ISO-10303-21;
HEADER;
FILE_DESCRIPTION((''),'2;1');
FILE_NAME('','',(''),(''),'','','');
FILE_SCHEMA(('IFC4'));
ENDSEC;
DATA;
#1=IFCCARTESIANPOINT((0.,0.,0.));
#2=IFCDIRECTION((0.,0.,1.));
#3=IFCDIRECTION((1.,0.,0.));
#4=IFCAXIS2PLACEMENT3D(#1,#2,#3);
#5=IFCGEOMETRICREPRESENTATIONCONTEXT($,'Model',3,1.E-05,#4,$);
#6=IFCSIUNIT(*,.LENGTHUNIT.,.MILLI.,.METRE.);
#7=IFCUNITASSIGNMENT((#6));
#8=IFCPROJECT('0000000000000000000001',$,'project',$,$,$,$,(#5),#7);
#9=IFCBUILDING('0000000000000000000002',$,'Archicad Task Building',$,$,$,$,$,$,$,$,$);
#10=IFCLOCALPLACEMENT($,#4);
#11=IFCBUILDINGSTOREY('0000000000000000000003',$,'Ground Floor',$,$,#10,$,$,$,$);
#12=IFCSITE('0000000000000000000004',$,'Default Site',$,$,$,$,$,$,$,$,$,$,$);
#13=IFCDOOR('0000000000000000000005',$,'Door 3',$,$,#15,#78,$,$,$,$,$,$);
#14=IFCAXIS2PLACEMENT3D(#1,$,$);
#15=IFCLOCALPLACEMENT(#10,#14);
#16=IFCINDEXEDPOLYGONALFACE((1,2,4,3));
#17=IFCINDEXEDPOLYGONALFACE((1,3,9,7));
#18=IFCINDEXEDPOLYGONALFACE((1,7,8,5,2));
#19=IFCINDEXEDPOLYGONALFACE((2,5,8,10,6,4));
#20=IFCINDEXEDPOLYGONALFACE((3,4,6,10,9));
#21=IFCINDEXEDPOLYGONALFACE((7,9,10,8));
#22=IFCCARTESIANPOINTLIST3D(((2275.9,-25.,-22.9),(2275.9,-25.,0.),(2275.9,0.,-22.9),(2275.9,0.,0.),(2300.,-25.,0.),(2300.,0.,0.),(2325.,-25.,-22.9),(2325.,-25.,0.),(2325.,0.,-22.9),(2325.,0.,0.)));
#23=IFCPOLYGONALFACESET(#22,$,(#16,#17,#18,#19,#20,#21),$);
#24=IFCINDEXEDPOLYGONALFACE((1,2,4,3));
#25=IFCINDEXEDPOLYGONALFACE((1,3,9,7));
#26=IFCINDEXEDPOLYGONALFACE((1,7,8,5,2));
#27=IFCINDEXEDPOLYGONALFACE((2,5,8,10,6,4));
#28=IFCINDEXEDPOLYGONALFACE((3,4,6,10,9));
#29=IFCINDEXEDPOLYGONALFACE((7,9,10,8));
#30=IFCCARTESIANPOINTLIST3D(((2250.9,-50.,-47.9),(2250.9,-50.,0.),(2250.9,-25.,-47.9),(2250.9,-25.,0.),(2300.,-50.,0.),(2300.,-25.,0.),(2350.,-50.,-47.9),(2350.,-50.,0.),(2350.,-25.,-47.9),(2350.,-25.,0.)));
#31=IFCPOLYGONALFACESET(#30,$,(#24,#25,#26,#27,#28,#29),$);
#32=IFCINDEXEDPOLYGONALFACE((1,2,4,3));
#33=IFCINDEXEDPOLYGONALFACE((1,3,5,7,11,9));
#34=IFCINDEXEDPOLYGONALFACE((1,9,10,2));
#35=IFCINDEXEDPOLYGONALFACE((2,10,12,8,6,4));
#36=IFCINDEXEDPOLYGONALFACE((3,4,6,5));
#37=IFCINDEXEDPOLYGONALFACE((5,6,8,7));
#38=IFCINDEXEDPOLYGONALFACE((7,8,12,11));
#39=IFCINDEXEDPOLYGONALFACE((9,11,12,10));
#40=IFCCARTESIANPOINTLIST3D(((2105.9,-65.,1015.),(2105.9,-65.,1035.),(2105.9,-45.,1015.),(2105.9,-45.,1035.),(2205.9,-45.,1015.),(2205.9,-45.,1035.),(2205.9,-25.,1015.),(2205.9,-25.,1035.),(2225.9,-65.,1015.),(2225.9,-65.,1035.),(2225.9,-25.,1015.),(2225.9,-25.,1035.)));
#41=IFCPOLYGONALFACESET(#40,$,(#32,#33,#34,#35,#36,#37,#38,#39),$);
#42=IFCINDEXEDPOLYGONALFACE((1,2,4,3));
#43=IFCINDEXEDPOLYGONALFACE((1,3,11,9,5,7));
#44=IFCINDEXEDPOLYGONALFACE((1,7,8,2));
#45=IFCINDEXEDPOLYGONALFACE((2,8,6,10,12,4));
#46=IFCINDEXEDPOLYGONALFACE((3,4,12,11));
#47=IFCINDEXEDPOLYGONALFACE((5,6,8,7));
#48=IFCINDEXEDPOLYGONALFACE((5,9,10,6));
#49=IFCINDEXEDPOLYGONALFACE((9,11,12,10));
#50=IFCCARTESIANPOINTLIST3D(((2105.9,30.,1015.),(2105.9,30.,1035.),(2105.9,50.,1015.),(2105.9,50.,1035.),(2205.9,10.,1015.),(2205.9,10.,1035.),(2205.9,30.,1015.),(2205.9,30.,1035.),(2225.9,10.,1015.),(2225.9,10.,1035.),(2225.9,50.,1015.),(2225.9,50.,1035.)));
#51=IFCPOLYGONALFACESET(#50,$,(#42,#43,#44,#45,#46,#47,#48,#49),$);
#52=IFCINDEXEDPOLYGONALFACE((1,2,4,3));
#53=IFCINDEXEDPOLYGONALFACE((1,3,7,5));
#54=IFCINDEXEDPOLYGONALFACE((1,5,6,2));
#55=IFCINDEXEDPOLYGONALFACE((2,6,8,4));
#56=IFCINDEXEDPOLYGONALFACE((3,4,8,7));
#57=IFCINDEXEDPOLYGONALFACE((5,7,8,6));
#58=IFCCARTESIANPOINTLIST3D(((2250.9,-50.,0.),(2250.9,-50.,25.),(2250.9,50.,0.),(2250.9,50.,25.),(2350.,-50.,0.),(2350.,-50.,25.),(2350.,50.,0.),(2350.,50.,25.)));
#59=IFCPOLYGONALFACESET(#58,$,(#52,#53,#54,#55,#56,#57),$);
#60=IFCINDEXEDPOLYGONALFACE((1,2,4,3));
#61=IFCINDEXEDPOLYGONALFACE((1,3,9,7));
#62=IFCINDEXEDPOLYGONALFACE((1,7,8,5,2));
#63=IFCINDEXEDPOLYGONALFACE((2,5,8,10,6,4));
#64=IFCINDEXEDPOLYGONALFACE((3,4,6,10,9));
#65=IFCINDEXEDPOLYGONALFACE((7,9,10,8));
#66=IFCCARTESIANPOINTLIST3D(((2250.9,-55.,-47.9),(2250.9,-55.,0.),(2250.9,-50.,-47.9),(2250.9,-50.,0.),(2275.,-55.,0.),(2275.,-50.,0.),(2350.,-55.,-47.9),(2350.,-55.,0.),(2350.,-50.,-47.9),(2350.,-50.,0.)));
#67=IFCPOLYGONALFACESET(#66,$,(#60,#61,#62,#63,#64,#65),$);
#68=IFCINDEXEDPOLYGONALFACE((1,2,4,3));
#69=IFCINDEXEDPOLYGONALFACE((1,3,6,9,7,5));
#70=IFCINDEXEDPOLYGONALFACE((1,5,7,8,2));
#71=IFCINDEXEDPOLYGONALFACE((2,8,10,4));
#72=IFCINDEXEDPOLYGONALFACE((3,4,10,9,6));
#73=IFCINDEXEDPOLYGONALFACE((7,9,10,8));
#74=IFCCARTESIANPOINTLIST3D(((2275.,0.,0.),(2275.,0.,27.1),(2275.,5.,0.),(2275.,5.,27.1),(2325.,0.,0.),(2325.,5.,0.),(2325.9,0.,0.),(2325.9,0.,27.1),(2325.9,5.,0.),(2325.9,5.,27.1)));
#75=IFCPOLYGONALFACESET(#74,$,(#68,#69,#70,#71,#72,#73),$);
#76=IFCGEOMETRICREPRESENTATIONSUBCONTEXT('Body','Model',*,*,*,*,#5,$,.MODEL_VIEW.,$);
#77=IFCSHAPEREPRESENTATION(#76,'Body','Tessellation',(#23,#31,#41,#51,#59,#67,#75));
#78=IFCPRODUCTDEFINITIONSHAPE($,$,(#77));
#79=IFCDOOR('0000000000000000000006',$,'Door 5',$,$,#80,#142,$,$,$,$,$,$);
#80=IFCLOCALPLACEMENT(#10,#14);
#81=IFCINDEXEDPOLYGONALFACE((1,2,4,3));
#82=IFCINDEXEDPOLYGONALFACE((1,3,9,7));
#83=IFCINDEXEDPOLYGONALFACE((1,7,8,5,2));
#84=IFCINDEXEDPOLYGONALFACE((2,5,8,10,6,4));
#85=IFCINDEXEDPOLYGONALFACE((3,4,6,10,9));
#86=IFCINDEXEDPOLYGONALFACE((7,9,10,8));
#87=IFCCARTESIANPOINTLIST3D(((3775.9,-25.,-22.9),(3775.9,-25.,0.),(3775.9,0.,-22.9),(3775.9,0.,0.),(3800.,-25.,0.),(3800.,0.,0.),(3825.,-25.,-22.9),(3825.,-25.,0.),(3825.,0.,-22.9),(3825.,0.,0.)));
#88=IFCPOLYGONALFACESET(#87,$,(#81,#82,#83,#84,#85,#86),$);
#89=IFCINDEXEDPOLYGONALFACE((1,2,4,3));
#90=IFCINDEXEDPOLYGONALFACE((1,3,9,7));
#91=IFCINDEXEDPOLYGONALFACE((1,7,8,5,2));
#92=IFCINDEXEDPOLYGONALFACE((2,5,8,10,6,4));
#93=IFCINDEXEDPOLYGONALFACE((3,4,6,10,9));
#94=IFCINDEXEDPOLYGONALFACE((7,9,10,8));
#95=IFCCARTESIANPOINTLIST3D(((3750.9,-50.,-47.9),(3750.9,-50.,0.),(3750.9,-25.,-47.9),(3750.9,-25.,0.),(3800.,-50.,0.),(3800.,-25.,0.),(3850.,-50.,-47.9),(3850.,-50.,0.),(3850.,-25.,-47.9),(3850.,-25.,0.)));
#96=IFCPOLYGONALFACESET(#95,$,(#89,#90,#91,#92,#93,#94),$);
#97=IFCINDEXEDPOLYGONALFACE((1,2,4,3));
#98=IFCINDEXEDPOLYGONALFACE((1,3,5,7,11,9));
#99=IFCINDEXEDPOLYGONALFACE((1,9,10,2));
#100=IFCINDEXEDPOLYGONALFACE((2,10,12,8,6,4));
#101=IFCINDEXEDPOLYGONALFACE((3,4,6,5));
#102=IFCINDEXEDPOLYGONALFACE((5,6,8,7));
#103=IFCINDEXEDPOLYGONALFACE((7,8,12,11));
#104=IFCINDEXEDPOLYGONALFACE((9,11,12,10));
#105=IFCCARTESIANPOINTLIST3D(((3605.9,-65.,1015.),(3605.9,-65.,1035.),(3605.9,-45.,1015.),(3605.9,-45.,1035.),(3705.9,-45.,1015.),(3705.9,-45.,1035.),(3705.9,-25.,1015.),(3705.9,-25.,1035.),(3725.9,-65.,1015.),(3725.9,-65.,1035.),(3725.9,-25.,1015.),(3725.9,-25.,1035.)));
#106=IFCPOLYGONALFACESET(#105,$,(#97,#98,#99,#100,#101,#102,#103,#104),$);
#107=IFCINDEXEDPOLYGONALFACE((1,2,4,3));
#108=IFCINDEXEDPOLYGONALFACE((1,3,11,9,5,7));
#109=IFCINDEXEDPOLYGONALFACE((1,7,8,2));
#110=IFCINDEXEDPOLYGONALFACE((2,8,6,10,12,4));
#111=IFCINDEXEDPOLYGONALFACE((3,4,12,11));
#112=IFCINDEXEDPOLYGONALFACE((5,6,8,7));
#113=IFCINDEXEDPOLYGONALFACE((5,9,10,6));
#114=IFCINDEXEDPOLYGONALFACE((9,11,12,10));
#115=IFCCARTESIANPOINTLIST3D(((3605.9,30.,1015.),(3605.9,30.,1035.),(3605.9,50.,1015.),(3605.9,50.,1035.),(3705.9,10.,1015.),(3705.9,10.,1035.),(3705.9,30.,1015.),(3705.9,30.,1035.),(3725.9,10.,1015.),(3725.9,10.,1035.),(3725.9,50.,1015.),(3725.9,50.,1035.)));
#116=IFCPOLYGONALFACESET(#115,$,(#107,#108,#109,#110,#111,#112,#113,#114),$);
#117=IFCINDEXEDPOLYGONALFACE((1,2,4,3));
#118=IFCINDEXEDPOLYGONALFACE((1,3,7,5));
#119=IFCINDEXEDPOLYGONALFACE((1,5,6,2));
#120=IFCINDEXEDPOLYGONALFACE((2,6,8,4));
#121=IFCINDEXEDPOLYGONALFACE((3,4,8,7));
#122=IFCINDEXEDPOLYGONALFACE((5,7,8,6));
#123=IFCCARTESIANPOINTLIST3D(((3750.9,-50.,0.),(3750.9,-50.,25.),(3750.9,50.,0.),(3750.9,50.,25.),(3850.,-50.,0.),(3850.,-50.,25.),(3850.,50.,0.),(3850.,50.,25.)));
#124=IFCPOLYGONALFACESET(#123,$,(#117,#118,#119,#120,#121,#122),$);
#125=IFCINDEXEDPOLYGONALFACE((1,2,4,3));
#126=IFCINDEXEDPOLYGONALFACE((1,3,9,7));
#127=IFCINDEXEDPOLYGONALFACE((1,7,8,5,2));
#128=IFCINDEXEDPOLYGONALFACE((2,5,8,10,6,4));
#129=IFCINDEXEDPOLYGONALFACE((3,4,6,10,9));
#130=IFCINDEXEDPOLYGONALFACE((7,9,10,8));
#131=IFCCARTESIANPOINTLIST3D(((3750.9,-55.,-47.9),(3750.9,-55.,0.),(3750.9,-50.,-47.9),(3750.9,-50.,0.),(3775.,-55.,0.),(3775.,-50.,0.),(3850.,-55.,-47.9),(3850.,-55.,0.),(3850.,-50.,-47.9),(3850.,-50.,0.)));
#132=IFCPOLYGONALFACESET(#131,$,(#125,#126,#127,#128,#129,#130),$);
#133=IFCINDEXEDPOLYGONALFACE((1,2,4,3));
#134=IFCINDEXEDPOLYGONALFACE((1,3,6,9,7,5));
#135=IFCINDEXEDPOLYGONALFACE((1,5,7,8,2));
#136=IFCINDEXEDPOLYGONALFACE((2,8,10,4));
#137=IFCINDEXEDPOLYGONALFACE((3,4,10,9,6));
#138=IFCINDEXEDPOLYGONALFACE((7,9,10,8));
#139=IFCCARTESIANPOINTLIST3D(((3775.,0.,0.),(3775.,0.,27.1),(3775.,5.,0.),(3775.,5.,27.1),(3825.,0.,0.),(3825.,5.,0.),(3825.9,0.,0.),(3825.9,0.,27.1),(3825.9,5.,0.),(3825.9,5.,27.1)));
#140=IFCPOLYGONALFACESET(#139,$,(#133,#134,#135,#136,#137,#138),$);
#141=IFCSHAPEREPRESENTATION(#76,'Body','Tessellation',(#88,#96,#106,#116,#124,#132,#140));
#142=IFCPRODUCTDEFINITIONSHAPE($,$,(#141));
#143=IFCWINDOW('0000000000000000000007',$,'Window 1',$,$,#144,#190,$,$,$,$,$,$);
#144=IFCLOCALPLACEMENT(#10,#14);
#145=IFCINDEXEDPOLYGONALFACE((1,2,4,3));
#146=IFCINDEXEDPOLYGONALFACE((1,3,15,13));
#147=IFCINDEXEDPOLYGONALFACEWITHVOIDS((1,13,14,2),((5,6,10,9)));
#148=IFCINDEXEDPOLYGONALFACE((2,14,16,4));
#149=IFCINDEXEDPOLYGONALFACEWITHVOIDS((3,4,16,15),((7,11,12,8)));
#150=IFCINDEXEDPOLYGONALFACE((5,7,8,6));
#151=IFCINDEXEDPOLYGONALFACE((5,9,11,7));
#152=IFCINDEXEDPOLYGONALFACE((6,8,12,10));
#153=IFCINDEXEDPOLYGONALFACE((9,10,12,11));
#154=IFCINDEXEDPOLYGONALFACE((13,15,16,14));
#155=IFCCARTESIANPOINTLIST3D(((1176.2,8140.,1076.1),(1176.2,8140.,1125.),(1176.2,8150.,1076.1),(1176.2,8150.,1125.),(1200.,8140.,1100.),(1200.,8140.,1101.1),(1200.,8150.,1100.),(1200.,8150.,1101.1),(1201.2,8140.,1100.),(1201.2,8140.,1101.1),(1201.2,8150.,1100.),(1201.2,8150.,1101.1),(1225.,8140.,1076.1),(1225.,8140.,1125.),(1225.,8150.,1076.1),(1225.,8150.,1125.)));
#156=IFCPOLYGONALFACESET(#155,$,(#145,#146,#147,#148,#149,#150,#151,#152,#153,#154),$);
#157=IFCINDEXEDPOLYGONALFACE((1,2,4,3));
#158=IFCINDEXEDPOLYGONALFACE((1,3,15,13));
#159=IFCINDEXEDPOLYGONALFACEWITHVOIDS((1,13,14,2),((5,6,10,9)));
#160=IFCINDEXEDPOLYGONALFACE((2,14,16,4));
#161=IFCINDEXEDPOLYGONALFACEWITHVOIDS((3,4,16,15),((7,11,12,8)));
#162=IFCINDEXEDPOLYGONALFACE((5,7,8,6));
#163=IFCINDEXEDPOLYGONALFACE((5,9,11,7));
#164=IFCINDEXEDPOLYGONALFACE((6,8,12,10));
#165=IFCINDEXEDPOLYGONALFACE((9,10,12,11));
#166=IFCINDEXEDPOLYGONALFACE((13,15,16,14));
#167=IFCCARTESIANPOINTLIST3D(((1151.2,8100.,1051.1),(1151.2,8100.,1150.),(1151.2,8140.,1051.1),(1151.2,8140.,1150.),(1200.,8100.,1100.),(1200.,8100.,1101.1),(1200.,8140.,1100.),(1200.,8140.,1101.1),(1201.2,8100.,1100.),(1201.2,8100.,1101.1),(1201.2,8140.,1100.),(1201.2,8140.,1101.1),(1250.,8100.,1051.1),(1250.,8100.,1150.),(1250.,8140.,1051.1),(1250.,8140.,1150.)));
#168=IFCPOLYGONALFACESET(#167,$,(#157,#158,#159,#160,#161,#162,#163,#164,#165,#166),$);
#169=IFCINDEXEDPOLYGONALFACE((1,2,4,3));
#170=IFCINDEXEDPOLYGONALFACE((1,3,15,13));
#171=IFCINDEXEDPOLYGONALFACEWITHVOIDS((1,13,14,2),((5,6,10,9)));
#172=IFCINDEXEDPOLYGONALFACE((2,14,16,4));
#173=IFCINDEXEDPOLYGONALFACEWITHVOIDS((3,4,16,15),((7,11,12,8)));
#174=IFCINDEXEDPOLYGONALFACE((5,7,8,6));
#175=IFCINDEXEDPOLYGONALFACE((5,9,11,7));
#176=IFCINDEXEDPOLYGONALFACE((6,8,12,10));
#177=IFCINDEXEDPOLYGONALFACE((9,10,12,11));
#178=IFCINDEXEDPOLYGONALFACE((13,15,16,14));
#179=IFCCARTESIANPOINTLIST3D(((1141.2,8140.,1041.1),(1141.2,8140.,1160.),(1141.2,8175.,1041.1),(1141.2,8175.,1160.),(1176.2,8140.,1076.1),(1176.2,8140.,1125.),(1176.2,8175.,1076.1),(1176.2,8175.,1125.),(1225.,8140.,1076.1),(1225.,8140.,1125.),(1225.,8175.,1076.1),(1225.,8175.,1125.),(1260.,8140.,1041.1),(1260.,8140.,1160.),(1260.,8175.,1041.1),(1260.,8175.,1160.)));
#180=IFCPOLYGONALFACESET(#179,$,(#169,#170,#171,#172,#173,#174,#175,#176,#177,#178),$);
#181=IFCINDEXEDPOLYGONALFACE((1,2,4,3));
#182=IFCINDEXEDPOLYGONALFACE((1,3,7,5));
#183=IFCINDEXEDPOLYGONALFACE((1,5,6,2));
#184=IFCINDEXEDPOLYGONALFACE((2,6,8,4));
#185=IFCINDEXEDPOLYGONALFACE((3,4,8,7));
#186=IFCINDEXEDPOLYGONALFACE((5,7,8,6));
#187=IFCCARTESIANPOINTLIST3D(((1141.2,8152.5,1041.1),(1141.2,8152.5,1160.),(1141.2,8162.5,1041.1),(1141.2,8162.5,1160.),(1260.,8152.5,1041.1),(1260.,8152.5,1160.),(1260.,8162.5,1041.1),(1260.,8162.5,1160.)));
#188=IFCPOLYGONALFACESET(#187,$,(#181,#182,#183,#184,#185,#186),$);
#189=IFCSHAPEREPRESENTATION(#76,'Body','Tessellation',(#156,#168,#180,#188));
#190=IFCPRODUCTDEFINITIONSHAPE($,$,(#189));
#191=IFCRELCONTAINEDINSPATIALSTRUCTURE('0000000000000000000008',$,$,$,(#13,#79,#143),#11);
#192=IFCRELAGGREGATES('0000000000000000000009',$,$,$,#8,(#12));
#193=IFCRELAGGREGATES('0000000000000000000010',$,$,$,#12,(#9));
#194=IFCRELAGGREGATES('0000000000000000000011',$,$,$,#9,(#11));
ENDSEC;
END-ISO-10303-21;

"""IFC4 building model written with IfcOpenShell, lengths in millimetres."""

from ifc_helpers import new_model, si_unit, frame, origin_with_axes, place, context, subcontext, project, spatial, line, indexed_curve, outline, extrude, element, save


model = new_model("IFC4")

# Units and contexts
model_context = context("Model", 3, precision=1e-05, world=origin_with_axes())
body_context = subcontext(model_context, "Body", "Model", "MODEL_VIEW")
ifc_project = project(units=[si_unit("LENGTHUNIT", "METRE", prefix="MILLI")], contexts=[model_context])

# Site, building, storey
site = spatial("IfcSite", under=ifc_project, Name="Default Site")
building = spatial("IfcBuilding", under=site, Name="Archicad Task Building")
storey_placement = place(None, origin_with_axes())
storey = spatial("IfcBuildingStorey", under=building, at=storey_placement, Name="Ground Floor")

# Doors
door_1_placement = place(storey_placement, frame((2300.0, -50.0, 0.0), z_axis=(0.0, 0.0, 1.0), x_axis=(1.0, 0.0, 0.0)))
element("IfcDoor", 1, at=door_1_placement, inside=storey, Name="Door 3", context=body_context, shape_type="SweptSolid", body=[
    extrude(outline(indexed_curve([(0.0, 0.0), (0.0, 2.1), (0.9, 2.1), (0.9, 0.0), (-24.1, 0.0), (-24.1, -22.9), (25.0, -22.9), (25.0, 0.0)], segments=[line(1, 2, 3, 4, 5, 6, 7, 8, 1)])), frame((0.0, 25.0, 0.0), z_axis=(0.0, -1.0, 0.0), x_axis=(1.0, 0.0, 0.0)), (0.0, 0.0, -1.0), 25.0),
    extrude(outline(indexed_curve([(0.0, 0.0), (0.0, 2.1), (0.9, 2.1), (0.9, 0.0), (-49.1, 0.0), (-49.1, -47.9), (50.0, -47.9), (50.0, 0.0)], segments=[line(1, 2, 3, 4, 5, 6, 7, 8, 1)])), frame((0.0, 0.0, 0.0), z_axis=(0.0, -1.0, 0.0), x_axis=(1.0, 0.0, 0.0)), (0.0, 0.0, -1.0), 25.0),
    extrude(outline(indexed_curve([(0.0, 0.0), (-49.1, 0.0), (-49.1, 35.0), (0.0, 35.0)], segments=[line(1, 2, 3, 4, 1)])), frame((25.0, 25.0, 25.0), z_axis=(0.0, 0.0, 1.0), x_axis=(1.0, 0.0, 0.0)), (0.0, 0.0, 1.0), -47.9),
    extrude(outline(indexed_curve([(0.0, 0.0), (0.0, -40.0), (-120.0, -40.0), (-120.0, -20.0), (-20.0, -20.0), (-20.0, 0.0)], segments=[line(1, 2, 3, 4, 5, 6, 1)])), frame((-74.1, 25.0, 1015.0), z_axis=(0.0, 0.0, 1.0), x_axis=(1.0, 0.0, 0.0)), (0.0, 0.0, 1.0), 20.0),
    extrude(outline(indexed_curve([(0.0, 0.0), (0.0, 40.0), (-120.0, 40.0), (-120.0, 20.0), (-20.0, 20.0), (-20.0, 0.0)], segments=[line(1, 2, 3, 4, 5, 6, 1)])), frame((-74.1, 60.0, 1015.0), z_axis=(0.0, 0.0, 1.0), x_axis=(1.0, 0.0, 0.0)), (0.0, 0.0, 1.0), 20.0),
    extrude(outline(indexed_curve([(0.0, 0.0), (-99.1, 0.0), (-99.1, 100.0), (0.0, 100.0)], segments=[line(1, 2, 3, 4, 1)])), frame((50.0, 0.0, 0.0), z_axis=(0.0, 0.0, 1.0), x_axis=(1.0, 0.0, 0.0)), (0.0, 0.0, 1.0), 25.0),
    extrude(outline(indexed_curve([(0.0, 0.0), (0.0, 27.1), (50.9, 27.1), (50.9, 0.0), (-24.1, 0.0), (-24.1, -47.9), (75.0, -47.9), (75.0, 0.0)], segments=[line(1, 2, 3, 4, 5, 6, 7, 8, 1)])), frame((-25.0, -5.0, 0.0), z_axis=(0.0, -1.0, 0.0), x_axis=(1.0, 0.0, 0.0)), (0.0, 0.0, -1.0), 5.0),
    extrude(outline(indexed_curve([(0.0, 0.0), (0.0, 27.1), (50.9, 27.1), (50.9, 0.0), (0.9, 0.0), (0.9, -22.9), (50.0, -22.9), (50.0, 0.0)], segments=[line(1, 2, 3, 4, 5, 6, 7, 8, 1)])), frame((-25.0, 50.0, 0.0), z_axis=(0.0, -1.0, 0.0), x_axis=(1.0, 0.0, 0.0)), (0.0, 0.0, -1.0), 5.0),
])
door_2_placement = place(storey_placement, frame((3800.0, -50.0, 0.0), z_axis=(0.0, 0.0, 1.0), x_axis=(1.0, 0.0, 0.0)))
element("IfcDoor", 2, at=door_2_placement, inside=storey, Name="Door 5", context=body_context, shape_type="SweptSolid", body=[
    extrude(outline(indexed_curve([(0.0, 0.0), (0.0, 2.1), (0.9, 2.1), (0.9, 0.0), (-24.1, 0.0), (-24.1, -22.9), (25.0, -22.9), (25.0, 0.0)], segments=[line(1, 2, 3, 4, 5, 6, 7, 8, 1)])), frame((0.0, 25.0, 0.0), z_axis=(0.0, -1.0, 0.0), x_axis=(1.0, 0.0, 0.0)), (0.0, 0.0, -1.0), 25.0),
    extrude(outline(indexed_curve([(0.0, 0.0), (0.0, 2.1), (0.9, 2.1), (0.9, 0.0), (-49.1, 0.0), (-49.1, -47.9), (50.0, -47.9), (50.0, 0.0)], segments=[line(1, 2, 3, 4, 5, 6, 7, 8, 1)])), frame((0.0, 0.0, 0.0), z_axis=(0.0, -1.0, 0.0), x_axis=(1.0, 0.0, 0.0)), (0.0, 0.0, -1.0), 25.0),
    extrude(outline(indexed_curve([(0.0, 0.0), (-49.1, 0.0), (-49.1, 35.0), (0.0, 35.0)], segments=[line(1, 2, 3, 4, 1)])), frame((25.0, 25.0, 25.0), z_axis=(0.0, 0.0, 1.0), x_axis=(1.0, 0.0, 0.0)), (0.0, 0.0, 1.0), -47.9),
    extrude(outline(indexed_curve([(0.0, 0.0), (0.0, -40.0), (-120.0, -40.0), (-120.0, -20.0), (-20.0, -20.0), (-20.0, 0.0)], segments=[line(1, 2, 3, 4, 5, 6, 1)])), frame((-74.1, 25.0, 1015.0), z_axis=(0.0, 0.0, 1.0), x_axis=(1.0, 0.0, 0.0)), (0.0, 0.0, 1.0), 20.0),
    extrude(outline(indexed_curve([(0.0, 0.0), (0.0, 40.0), (-120.0, 40.0), (-120.0, 20.0), (-20.0, 20.0), (-20.0, 0.0)], segments=[line(1, 2, 3, 4, 5, 6, 1)])), frame((-74.1, 60.0, 1015.0), z_axis=(0.0, 0.0, 1.0), x_axis=(1.0, 0.0, 0.0)), (0.0, 0.0, 1.0), 20.0),
    extrude(outline(indexed_curve([(0.0, 0.0), (-99.1, 0.0), (-99.1, 100.0), (0.0, 100.0)], segments=[line(1, 2, 3, 4, 1)])), frame((50.0, 0.0, 0.0), z_axis=(0.0, 0.0, 1.0), x_axis=(1.0, 0.0, 0.0)), (0.0, 0.0, 1.0), 25.0),
    extrude(outline(indexed_curve([(0.0, 0.0), (0.0, 27.1), (50.9, 27.1), (50.9, 0.0), (-24.1, 0.0), (-24.1, -47.9), (75.0, -47.9), (75.0, 0.0)], segments=[line(1, 2, 3, 4, 5, 6, 7, 8, 1)])), frame((-25.0, -5.0, 0.0), z_axis=(0.0, -1.0, 0.0), x_axis=(1.0, 0.0, 0.0)), (0.0, 0.0, -1.0), 5.0),
    extrude(outline(indexed_curve([(0.0, 0.0), (0.0, 27.1), (50.9, 27.1), (50.9, 0.0), (0.9, 0.0), (0.9, -22.9), (50.0, -22.9), (50.0, 0.0)], segments=[line(1, 2, 3, 4, 5, 6, 7, 8, 1)])), frame((-25.0, 50.0, 0.0), z_axis=(0.0, -1.0, 0.0), x_axis=(1.0, 0.0, 0.0)), (0.0, 0.0, -1.0), 5.0),
])

# Window
for number, where, z_axis, x_axis, name in (
    (3, (1200.0, 8050.0, 1100.0), (0.0, 0.0, 1.0), (1.0, 0.0, 0.0), "Window 1"),
):
    element("IfcWindow", number, at=place(storey_placement, frame(where, z_axis=z_axis, x_axis=x_axis)), inside=storey, Name=name, context=body_context, shape_type="SweptSolid", body=[
        extrude(outline(indexed_curve([(0.0, 0.0), (1.2, 0.0), (1.2, 1.1), (0.0, 1.1)], segments=[line(1, 2, 3, 4, 1)]), holes=[indexed_curve([(25.0, 25.0), (-23.8, 25.0), (-23.8, -23.9), (25.0, -23.9)], segments=[line(1, 2, 3, 4, 1)])]), frame((0.0, 90.0, 0.0), z_axis=(0.0, -1.0, 0.0), x_axis=(1.0, 0.0, 0.0)), (0.0, 0.0, -1.0), 10.0),
        extrude(outline(indexed_curve([(0.0, 0.0), (1.2, 0.0), (1.2, 1.1), (0.0, 1.1)], segments=[line(1, 2, 3, 4, 1)]), holes=[indexed_curve([(50.0, 50.0), (-48.8, 50.0), (-48.8, -48.9), (50.0, -48.9)], segments=[line(1, 2, 3, 4, 1)])]), frame((0.0, 50.0, 0.0), z_axis=(0.0, -1.0, 0.0), x_axis=(1.0, 0.0, 0.0)), (0.0, 0.0, -1.0), 40.0),
        extrude(outline(indexed_curve([(0.0, 0.0), (-48.8, 0.0), (-48.8, -48.9), (0.0, -48.9)], segments=[line(1, 2, 3, 4, 1)]), holes=[indexed_curve([(35.0, 35.0), (-83.8, 35.0), (-83.8, -83.9), (35.0, -83.9)], segments=[line(1, 2, 3, 4, 1)])]), frame((25.0, 90.0, 25.0), z_axis=(0.0, -1.0, 0.0), x_axis=(1.0, 0.0, 0.0)), (0.0, 0.0, -1.0), 35.0),
        extrude(outline(indexed_curve([(35.0, 35.0), (-83.8, 35.0), (-83.8, -83.9), (35.0, -83.9)], segments=[line(1, 2, 3, 4, 1)])), frame((25.0, 102.5, 25.0), z_axis=(0.0, -1.0, 0.0), x_axis=(1.0, 0.0, 0.0)), (0.0, 0.0, -1.0), 10.0),
    ])

save(model, "model.ifc")
